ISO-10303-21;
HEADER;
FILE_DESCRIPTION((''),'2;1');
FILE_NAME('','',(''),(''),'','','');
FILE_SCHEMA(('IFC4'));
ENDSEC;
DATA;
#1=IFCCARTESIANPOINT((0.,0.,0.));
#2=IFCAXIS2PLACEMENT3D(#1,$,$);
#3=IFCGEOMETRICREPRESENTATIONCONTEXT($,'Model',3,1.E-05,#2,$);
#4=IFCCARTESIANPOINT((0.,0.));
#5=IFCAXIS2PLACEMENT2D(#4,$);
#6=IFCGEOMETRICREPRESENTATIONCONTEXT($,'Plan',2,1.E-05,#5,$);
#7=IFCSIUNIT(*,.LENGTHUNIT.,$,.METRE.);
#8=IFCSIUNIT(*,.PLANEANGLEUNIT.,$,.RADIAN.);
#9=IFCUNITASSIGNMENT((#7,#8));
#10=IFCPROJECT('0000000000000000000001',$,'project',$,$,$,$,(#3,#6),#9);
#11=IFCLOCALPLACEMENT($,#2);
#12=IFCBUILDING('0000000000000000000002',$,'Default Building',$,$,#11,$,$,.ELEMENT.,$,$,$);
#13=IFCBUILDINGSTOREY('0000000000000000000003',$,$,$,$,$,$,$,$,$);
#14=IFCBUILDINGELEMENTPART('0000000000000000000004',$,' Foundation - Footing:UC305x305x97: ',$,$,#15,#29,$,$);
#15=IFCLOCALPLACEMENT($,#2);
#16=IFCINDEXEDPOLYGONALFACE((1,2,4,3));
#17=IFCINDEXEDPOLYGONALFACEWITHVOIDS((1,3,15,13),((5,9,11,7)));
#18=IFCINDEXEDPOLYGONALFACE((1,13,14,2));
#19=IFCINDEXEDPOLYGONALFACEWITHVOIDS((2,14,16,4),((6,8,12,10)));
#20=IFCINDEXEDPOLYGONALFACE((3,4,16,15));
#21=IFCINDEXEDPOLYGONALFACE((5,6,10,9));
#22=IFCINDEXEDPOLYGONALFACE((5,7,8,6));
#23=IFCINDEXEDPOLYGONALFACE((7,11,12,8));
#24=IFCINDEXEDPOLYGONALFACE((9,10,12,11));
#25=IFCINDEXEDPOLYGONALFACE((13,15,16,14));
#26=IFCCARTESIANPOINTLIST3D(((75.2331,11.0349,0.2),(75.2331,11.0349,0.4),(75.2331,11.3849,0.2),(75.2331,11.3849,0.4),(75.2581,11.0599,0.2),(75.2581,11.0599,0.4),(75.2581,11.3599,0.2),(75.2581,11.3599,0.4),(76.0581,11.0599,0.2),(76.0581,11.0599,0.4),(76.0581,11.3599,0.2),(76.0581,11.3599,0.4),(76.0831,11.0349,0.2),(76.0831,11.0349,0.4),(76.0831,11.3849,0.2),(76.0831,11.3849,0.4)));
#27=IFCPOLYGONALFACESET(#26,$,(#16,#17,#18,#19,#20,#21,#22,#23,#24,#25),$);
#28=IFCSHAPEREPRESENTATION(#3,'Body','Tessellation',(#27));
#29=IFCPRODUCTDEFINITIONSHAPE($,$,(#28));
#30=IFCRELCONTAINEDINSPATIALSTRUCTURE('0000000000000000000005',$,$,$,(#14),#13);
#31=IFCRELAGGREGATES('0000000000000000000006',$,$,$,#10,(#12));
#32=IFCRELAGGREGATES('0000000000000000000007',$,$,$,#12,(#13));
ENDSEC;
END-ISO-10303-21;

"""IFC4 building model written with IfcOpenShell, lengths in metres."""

from ifc_helpers import new_model, si_unit, origin, origin_2d, place, context, project, spatial, polyline, outline, extrude, element, save


model = new_model("IFC4")

# Units and contexts
model_context = context("Model", 3, precision=1e-05, world=origin())
plan_context = context("Plan", 2, precision=1e-05, world=origin_2d())
ifc_project = project(units=[si_unit("LENGTHUNIT", "METRE"), si_unit("PLANEANGLEUNIT", "RADIAN")], contexts=[model_context, plan_context])

# Building, storey
building_placement = place(None, origin())
building = spatial("IfcBuilding", under=ifc_project, at=building_placement, Name="Default Building", CompositionType="ELEMENT")
storey = spatial("IfcBuildingStorey", under=building)

# Building element part, opening
building_element_part_1 = element("IfcBuildingElementPart", 1, inside=storey, Name=" Foundation - Footing:UC305x305x97: ", context=model_context, shape_type="SweptSolid", body=[
    extrude(outline(polyline([(75.2331, 11.0349, 0.2), (76.0831, 11.0349, 0.2), (76.0831, 11.3849, 0.2), (75.2331, 11.3849, 0.2), (75.2331, 11.0349, 0.2)])), None, (0.0, 0.0, 1.0), 0.2),
])
element("IfcOpeningElement", 2, inside=storey, cuts=building_element_part_1, context=model_context, shape_type="SweptSolid", body=[
    extrude(outline(polyline([(75.2581, 11.0599, 0.2), (76.0581, 11.0599, 0.2), (76.0581, 11.3599, 0.2), (75.2581, 11.3599, 0.2), (75.2581, 11.0599, 0.2)])), None, (0.0, 0.0, 1.0), 0.2),
])

save(model, "model.ifc")
